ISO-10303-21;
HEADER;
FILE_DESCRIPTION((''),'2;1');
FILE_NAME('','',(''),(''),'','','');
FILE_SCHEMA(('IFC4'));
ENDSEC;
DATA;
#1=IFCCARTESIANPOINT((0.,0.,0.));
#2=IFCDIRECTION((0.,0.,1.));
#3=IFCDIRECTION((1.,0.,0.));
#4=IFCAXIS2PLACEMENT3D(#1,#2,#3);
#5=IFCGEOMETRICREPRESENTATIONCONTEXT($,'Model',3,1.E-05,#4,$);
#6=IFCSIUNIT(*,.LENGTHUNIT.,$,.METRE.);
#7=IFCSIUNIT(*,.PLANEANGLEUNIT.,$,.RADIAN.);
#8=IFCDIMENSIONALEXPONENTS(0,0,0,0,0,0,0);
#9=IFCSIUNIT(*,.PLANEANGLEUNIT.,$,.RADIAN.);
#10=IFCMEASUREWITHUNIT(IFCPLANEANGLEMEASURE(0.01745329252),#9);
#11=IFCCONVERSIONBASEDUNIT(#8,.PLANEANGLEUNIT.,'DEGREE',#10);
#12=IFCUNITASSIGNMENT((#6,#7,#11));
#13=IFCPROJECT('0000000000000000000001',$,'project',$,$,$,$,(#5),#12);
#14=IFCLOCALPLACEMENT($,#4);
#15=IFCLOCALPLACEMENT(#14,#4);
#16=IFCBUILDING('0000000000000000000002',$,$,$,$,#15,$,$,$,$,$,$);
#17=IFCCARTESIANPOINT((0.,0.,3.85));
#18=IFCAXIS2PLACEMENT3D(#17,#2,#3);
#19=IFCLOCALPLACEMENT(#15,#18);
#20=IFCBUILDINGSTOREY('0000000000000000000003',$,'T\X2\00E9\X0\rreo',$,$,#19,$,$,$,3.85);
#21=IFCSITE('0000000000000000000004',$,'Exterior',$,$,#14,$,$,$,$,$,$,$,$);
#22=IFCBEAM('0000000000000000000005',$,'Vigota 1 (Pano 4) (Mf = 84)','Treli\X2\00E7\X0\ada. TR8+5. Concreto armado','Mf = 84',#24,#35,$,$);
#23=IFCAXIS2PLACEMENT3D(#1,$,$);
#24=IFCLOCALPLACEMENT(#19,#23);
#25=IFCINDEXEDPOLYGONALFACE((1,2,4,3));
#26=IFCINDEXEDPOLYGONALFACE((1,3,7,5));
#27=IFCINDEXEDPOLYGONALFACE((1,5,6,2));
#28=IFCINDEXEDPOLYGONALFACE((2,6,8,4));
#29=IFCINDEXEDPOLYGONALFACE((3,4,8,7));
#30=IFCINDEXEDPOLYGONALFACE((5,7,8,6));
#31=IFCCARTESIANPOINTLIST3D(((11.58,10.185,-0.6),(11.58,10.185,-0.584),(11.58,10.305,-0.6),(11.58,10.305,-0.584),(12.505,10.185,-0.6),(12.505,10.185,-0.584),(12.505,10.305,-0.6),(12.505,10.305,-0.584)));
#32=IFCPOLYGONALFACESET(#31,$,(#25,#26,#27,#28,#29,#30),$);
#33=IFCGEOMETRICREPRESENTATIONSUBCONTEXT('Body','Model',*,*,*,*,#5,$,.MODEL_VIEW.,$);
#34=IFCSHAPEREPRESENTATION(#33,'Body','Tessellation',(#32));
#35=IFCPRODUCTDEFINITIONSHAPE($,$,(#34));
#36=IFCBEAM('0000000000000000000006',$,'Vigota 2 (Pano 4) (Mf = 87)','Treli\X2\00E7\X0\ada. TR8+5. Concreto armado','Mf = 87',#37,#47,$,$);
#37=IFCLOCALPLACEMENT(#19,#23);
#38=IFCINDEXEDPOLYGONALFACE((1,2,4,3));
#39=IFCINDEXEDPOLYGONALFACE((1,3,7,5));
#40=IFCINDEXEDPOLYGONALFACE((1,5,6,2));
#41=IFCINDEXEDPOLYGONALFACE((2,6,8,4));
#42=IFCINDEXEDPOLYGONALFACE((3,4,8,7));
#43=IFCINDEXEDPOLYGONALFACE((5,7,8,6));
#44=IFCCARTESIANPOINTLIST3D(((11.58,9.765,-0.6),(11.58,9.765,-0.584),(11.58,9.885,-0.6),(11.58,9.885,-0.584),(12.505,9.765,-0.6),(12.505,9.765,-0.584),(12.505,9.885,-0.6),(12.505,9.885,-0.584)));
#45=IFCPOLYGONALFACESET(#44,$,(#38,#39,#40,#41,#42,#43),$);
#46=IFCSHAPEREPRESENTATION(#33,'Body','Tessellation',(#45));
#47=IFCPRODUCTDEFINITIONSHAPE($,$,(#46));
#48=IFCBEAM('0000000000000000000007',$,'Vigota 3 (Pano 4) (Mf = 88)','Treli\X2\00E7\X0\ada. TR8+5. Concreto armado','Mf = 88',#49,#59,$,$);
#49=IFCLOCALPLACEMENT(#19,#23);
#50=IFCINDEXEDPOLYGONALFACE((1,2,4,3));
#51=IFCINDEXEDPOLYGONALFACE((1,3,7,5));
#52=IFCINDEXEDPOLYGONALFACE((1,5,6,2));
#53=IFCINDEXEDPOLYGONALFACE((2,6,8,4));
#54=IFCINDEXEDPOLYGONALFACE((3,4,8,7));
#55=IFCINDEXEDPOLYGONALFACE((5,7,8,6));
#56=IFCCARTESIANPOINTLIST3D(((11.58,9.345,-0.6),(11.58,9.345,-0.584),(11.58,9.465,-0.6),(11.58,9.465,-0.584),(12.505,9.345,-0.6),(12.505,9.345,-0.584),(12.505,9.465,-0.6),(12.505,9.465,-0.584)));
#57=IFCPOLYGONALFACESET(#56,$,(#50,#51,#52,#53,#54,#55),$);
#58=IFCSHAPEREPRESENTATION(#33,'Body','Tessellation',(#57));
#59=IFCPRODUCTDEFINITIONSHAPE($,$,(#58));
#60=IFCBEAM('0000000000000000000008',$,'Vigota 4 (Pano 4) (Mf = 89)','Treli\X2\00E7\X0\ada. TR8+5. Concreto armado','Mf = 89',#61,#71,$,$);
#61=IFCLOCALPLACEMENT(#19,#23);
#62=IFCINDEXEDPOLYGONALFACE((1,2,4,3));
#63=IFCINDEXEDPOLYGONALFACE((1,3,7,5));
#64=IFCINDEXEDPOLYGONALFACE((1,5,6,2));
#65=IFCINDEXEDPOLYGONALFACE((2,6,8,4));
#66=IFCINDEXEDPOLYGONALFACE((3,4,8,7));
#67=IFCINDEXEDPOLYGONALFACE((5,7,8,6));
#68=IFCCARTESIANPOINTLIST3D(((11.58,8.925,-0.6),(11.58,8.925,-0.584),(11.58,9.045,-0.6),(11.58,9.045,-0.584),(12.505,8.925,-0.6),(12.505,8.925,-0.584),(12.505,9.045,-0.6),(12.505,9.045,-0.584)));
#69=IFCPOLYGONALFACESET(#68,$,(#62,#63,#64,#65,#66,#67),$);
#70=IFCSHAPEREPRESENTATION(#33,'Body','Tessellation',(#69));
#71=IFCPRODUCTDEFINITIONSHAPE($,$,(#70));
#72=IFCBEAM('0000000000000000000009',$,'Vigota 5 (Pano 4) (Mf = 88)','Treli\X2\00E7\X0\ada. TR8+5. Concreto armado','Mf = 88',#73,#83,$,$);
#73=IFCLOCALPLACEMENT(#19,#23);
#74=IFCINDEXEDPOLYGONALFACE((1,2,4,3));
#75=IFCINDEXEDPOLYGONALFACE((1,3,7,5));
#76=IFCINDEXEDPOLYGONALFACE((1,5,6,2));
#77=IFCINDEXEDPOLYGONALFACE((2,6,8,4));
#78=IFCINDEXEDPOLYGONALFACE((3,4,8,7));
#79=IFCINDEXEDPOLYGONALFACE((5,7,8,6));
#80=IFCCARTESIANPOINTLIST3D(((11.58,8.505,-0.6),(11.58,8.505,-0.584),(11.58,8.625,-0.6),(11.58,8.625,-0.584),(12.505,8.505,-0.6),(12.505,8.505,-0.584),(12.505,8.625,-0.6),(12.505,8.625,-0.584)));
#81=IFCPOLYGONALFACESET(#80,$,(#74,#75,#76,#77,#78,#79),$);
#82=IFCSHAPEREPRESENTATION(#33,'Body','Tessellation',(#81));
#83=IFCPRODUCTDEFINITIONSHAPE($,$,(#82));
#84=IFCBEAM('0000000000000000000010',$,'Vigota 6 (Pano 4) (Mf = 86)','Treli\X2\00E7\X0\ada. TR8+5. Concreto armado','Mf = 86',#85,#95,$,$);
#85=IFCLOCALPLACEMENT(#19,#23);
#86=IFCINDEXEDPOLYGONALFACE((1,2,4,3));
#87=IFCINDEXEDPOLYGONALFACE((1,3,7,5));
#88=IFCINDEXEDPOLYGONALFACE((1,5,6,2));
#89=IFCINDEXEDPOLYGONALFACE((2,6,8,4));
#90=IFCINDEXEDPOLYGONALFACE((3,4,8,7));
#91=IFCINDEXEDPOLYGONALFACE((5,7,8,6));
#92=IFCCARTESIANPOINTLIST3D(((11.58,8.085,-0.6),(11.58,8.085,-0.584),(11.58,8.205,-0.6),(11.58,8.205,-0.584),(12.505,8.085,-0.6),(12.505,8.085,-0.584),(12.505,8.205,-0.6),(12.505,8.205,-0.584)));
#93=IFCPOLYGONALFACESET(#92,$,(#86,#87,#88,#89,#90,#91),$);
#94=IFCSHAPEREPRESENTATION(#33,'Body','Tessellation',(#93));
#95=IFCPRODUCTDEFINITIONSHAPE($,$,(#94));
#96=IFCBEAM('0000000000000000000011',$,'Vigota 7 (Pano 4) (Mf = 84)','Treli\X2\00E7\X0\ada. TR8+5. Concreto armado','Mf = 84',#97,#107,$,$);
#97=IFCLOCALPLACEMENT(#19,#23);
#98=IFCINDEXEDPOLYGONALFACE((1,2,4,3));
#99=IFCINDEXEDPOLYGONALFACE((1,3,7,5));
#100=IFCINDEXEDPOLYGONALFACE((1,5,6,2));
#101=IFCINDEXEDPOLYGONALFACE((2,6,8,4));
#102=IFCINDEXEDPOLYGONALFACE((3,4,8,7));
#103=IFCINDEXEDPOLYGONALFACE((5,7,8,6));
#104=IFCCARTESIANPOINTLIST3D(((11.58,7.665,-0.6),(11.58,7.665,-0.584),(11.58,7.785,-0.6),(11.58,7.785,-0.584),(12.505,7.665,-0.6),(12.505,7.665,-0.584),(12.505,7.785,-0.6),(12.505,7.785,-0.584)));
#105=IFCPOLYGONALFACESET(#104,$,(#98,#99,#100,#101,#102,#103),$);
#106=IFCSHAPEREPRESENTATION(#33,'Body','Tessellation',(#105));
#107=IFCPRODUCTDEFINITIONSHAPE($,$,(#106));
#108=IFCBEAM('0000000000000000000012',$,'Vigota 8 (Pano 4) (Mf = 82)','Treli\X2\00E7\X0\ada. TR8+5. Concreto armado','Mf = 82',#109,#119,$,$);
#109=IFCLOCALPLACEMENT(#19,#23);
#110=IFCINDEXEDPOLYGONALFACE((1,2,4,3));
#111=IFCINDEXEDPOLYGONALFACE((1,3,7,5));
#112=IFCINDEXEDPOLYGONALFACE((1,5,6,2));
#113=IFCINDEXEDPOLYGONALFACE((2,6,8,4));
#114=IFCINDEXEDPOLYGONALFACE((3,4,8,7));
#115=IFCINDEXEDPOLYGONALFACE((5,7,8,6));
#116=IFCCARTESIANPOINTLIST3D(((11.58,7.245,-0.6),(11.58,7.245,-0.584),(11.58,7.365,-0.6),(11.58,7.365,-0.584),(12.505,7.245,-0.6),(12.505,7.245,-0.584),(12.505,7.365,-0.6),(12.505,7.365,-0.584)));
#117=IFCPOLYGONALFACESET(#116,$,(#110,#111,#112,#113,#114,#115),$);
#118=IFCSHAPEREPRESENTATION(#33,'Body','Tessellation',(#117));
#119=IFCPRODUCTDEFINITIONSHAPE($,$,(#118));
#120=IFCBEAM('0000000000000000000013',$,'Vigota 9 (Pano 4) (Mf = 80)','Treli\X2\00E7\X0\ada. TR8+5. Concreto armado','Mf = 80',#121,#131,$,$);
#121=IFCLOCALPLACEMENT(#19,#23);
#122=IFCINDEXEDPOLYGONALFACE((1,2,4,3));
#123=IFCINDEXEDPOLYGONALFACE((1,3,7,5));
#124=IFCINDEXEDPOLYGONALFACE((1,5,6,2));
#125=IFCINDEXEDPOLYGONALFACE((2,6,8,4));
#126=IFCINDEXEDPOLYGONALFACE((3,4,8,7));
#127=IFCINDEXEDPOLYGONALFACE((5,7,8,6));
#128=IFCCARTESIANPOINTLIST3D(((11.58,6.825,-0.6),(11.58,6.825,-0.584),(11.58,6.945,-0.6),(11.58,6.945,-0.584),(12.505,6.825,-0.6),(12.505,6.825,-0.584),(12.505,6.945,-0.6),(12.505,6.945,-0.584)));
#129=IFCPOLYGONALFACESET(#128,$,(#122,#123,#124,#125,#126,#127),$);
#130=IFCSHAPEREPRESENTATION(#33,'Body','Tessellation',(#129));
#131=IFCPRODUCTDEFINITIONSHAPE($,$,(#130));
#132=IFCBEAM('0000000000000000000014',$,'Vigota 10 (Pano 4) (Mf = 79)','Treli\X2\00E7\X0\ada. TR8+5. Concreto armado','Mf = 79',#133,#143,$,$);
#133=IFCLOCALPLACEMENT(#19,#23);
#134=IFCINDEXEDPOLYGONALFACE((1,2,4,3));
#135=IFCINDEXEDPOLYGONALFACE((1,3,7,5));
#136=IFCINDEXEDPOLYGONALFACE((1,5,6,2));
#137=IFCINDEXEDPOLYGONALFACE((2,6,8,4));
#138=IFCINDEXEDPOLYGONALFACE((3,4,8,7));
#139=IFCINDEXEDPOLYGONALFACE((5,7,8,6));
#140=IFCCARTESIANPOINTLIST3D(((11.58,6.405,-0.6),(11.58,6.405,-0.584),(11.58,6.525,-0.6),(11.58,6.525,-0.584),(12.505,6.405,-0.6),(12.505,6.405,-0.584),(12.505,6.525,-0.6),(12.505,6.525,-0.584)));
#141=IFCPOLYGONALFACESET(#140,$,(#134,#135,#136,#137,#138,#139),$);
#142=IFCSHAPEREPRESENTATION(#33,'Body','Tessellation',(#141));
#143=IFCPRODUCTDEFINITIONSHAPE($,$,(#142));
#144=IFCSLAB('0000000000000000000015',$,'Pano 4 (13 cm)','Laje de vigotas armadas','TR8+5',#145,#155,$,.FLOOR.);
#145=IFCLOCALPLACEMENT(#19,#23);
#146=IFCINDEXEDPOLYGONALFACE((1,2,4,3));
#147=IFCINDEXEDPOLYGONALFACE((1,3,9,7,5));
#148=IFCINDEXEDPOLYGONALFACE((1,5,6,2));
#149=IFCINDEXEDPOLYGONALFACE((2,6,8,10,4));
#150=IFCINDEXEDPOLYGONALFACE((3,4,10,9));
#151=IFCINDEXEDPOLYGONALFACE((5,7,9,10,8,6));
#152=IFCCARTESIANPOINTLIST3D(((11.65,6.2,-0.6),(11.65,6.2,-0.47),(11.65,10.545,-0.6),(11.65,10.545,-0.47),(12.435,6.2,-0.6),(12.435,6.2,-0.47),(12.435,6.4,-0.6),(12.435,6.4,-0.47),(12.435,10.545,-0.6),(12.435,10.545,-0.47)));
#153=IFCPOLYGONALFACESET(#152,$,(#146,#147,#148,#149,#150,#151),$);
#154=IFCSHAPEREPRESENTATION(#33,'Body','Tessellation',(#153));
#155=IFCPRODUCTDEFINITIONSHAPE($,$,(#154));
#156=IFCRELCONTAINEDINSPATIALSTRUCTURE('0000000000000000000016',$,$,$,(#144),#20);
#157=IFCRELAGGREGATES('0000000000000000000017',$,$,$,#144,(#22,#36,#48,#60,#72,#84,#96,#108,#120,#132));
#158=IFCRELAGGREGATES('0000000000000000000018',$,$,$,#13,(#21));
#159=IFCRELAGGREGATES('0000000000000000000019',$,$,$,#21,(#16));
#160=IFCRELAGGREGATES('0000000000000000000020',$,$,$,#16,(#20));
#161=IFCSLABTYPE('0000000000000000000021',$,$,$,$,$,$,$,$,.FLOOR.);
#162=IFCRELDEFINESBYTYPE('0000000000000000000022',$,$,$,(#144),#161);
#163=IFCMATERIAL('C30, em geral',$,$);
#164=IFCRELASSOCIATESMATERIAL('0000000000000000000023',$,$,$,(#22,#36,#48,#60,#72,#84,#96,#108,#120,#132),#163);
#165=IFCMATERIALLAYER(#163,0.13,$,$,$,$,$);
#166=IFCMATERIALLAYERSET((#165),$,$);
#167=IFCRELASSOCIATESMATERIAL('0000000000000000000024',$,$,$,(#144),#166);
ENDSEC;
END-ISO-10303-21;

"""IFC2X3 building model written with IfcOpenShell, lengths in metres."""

from ifc_helpers import new_model, entity, si_unit, converted_unit, frame, origin_with_axes, place, context, subcontext, project, spatial, polyline, outline, extrude, material, layer, layer_set, layer_usage, type_object, element, aggregate, save


model = new_model("IFC2X3")

# Units and contexts
model_context = context("Model", 3, precision=1e-05, world=origin_with_axes())
body_context = subcontext(model_context, "Body", "Model", "MODEL_VIEW")
ifc_project = project(units=[si_unit("LENGTHUNIT", "METRE"), si_unit("PLANEANGLEUNIT", "RADIAN"), converted_unit("PLANEANGLEUNIT", "DEGREE", entity("IfcPlaneAngleMeasure", 0.01745329252), si_unit("PLANEANGLEUNIT", "RADIAN"), dimensions=[0, 0, 0, 0, 0, 0, 0])], contexts=[model_context])

# Beams
ifc_material = material(Name="C30, em geral")
site_placement = place(None, origin_with_axes())
building_placement = place(site_placement, origin_with_axes())
storey_placement = place(building_placement, frame((0.0, 0.0, 3.85), z_axis=(0.0, 0.0, 1.0), x_axis=(1.0, 0.0, 0.0)))
beam_1_placement = place(storey_placement, frame((11.58, 10.245, -0.592), z_axis=(1.0, 0.0, 0.0), x_axis=(0.0, 1.0, 0.0)))
beam_1 = element("IfcBeam", 1, at=beam_1_placement, material=ifc_material, Name="Vigota 1 (Pano 4) (Mf = 84)", Description="Treliçada. TR8+5. Concreto armado", ObjectType="Mf = 84", context=body_context, shape_type="SweptSolid", body=[
    extrude(outline(polyline([(0.06, 0.008), (-0.06, 0.008), (-0.06, -0.008), (0.06, -0.008), (0.06, 0.008)])), origin_with_axes(), (0.0, 0.0, 1.0), 0.925),
])
beam_2_placement = place(storey_placement, frame((11.58, 9.825, -0.592), z_axis=(1.0, 0.0, 0.0), x_axis=(0.0, 1.0, 0.0)))
beam_2 = element("IfcBeam", 2, at=beam_2_placement, material=ifc_material, Name="Vigota 2 (Pano 4) (Mf = 87)", Description="Treliçada. TR8+5. Concreto armado", ObjectType="Mf = 87", context=body_context, shape_type="SweptSolid", body=[
    extrude(outline(polyline([(0.06, 0.008), (-0.06, 0.008), (-0.06, -0.008), (0.06, -0.008), (0.06, 0.008)])), origin_with_axes(), (0.0, 0.0, 1.0), 0.925),
])
beam_3_placement = place(storey_placement, frame((11.58, 9.405, -0.592), z_axis=(1.0, 0.0, 0.0), x_axis=(0.0, 1.0, 0.0)))
beam_3 = element("IfcBeam", 3, at=beam_3_placement, material=ifc_material, Name="Vigota 3 (Pano 4) (Mf = 88)", Description="Treliçada. TR8+5. Concreto armado", ObjectType="Mf = 88", context=body_context, shape_type="SweptSolid", body=[
    extrude(outline(polyline([(0.06, 0.008), (-0.06, 0.008), (-0.06, -0.008), (0.06, -0.008), (0.06, 0.008)])), origin_with_axes(), (0.0, 0.0, 1.0), 0.925),
])
beam_4_placement = place(storey_placement, frame((11.58, 8.985, -0.592), z_axis=(1.0, 0.0, 0.0), x_axis=(0.0, 1.0, 0.0)))
beam_4 = element("IfcBeam", 4, at=beam_4_placement, material=ifc_material, Name="Vigota 4 (Pano 4) (Mf = 89)", Description="Treliçada. TR8+5. Concreto armado", ObjectType="Mf = 89", context=body_context, shape_type="SweptSolid", body=[
    extrude(outline(polyline([(0.06, 0.008), (-0.06, 0.008), (-0.06, -0.008), (0.06, -0.008), (0.06, 0.008)])), origin_with_axes(), (0.0, 0.0, 1.0), 0.925),
])
beam_5_placement = place(storey_placement, frame((11.58, 8.565, -0.592), z_axis=(1.0, 0.0, 0.0), x_axis=(0.0, 1.0, 0.0)))
beam_5 = element("IfcBeam", 5, at=beam_5_placement, material=ifc_material, Name="Vigota 5 (Pano 4) (Mf = 88)", Description="Treliçada. TR8+5. Concreto armado", ObjectType="Mf = 88", context=body_context, shape_type="SweptSolid", body=[
    extrude(outline(polyline([(0.06, 0.008), (-0.06, 0.008), (-0.06, -0.008), (0.06, -0.008), (0.06, 0.008)])), origin_with_axes(), (0.0, 0.0, 1.0), 0.925),
])
beam_6_placement = place(storey_placement, frame((11.58, 8.145, -0.592), z_axis=(1.0, 0.0, 0.0), x_axis=(0.0, 1.0, 0.0)))
beam_6 = element("IfcBeam", 6, at=beam_6_placement, material=ifc_material, Name="Vigota 6 (Pano 4) (Mf = 86)", Description="Treliçada. TR8+5. Concreto armado", ObjectType="Mf = 86", context=body_context, shape_type="SweptSolid", body=[
    extrude(outline(polyline([(0.06, 0.008), (-0.06, 0.008), (-0.06, -0.008), (0.06, -0.008), (0.06, 0.008)])), origin_with_axes(), (0.0, 0.0, 1.0), 0.925),
])
beam_7_placement = place(storey_placement, frame((11.58, 7.725, -0.592), z_axis=(1.0, 0.0, 0.0), x_axis=(0.0, 1.0, 0.0)))
beam_7 = element("IfcBeam", 7, at=beam_7_placement, material=ifc_material, Name="Vigota 7 (Pano 4) (Mf = 84)", Description="Treliçada. TR8+5. Concreto armado", ObjectType="Mf = 84", context=body_context, shape_type="SweptSolid", body=[
    extrude(outline(polyline([(0.06, 0.008), (-0.06, 0.008), (-0.06, -0.008), (0.06, -0.008), (0.06, 0.008)])), origin_with_axes(), (0.0, 0.0, 1.0), 0.925),
])
beam_8_placement = place(storey_placement, frame((11.58, 7.305, -0.592), z_axis=(1.0, 0.0, 0.0), x_axis=(0.0, 1.0, 0.0)))
beam_8 = element("IfcBeam", 8, at=beam_8_placement, material=ifc_material, Name="Vigota 8 (Pano 4) (Mf = 82)", Description="Treliçada. TR8+5. Concreto armado", ObjectType="Mf = 82", context=body_context, shape_type="SweptSolid", body=[
    extrude(outline(polyline([(0.06, 0.008), (-0.06, 0.008), (-0.06, -0.008), (0.06, -0.008), (0.06, 0.008)])), origin_with_axes(), (0.0, 0.0, 1.0), 0.925),
])
beam_9_placement = place(storey_placement, frame((11.58, 6.885, -0.592), z_axis=(1.0, 0.0, 0.0), x_axis=(0.0, 1.0, 0.0)))
beam_9 = element("IfcBeam", 9, at=beam_9_placement, material=ifc_material, Name="Vigota 9 (Pano 4) (Mf = 80)", Description="Treliçada. TR8+5. Concreto armado", ObjectType="Mf = 80", context=body_context, shape_type="SweptSolid", body=[
    extrude(outline(polyline([(0.06, 0.008), (-0.06, 0.008), (-0.06, -0.008), (0.06, -0.008), (0.06, 0.008)])), origin_with_axes(), (0.0, 0.0, 1.0), 0.925),
])
beam_10_placement = place(storey_placement, frame((11.58, 6.465, -0.592), z_axis=(1.0, 0.0, 0.0), x_axis=(0.0, 1.0, 0.0)))
beam_10 = element("IfcBeam", 10, at=beam_10_placement, material=ifc_material, Name="Vigota 10 (Pano 4) (Mf = 79)", Description="Treliçada. TR8+5. Concreto armado", ObjectType="Mf = 79", context=body_context, shape_type="SweptSolid", body=[
    extrude(outline(polyline([(0.06, 0.008), (-0.06, 0.008), (-0.06, -0.008), (0.06, -0.008), (0.06, 0.008)])), origin_with_axes(), (0.0, 0.0, 1.0), 0.925),
])

# Site, building, storey
site = spatial("IfcSite", under=ifc_project, at=site_placement, Name="Exterior")
building = spatial("IfcBuilding", under=site, at=building_placement)
storey = spatial("IfcBuildingStorey", under=building, at=storey_placement, Name="Térreo", Elevation=3.85)

# Slab
slab_type = type_object("IfcSlabType", PredefinedType="FLOOR")
ifc_layer_1 = layer(ifc_material, 0.13)
ifc_layer_set_1 = layer_set([ifc_layer_1])
ifc_layer_usage_1 = layer_usage(ifc_layer_set_1, "AXIS3", "POSITIVE", 0.0)
slab_1_placement = place(storey_placement, frame((0.0, 0.0, -0.6), z_axis=(0.0, 0.0, 1.0), x_axis=(1.0, 0.0, 0.0)))
slab_1 = element("IfcSlab", 11, at=slab_1_placement, inside=storey, type_object=slab_type, material=ifc_layer_usage_1, Name="Pano 4 (13 cm)", Description="Laje de vigotas armadas", ObjectType="TR8+5", PredefinedType="FLOOR", context=body_context, shape_type="SweptSolid", body=[
    extrude(outline(polyline([(12.435, 6.4), (12.435, 10.545), (11.65, 10.545), (11.65, 6.2), (12.435, 6.2), (12.435, 6.4)])), origin_with_axes(), (0.0, 0.0, 1.0), 0.13),
])
aggregate(slab_1, [beam_1, beam_2, beam_3, beam_4, beam_5, beam_6, beam_7, beam_8, beam_9, beam_10])

save(model, "model.ifc")
